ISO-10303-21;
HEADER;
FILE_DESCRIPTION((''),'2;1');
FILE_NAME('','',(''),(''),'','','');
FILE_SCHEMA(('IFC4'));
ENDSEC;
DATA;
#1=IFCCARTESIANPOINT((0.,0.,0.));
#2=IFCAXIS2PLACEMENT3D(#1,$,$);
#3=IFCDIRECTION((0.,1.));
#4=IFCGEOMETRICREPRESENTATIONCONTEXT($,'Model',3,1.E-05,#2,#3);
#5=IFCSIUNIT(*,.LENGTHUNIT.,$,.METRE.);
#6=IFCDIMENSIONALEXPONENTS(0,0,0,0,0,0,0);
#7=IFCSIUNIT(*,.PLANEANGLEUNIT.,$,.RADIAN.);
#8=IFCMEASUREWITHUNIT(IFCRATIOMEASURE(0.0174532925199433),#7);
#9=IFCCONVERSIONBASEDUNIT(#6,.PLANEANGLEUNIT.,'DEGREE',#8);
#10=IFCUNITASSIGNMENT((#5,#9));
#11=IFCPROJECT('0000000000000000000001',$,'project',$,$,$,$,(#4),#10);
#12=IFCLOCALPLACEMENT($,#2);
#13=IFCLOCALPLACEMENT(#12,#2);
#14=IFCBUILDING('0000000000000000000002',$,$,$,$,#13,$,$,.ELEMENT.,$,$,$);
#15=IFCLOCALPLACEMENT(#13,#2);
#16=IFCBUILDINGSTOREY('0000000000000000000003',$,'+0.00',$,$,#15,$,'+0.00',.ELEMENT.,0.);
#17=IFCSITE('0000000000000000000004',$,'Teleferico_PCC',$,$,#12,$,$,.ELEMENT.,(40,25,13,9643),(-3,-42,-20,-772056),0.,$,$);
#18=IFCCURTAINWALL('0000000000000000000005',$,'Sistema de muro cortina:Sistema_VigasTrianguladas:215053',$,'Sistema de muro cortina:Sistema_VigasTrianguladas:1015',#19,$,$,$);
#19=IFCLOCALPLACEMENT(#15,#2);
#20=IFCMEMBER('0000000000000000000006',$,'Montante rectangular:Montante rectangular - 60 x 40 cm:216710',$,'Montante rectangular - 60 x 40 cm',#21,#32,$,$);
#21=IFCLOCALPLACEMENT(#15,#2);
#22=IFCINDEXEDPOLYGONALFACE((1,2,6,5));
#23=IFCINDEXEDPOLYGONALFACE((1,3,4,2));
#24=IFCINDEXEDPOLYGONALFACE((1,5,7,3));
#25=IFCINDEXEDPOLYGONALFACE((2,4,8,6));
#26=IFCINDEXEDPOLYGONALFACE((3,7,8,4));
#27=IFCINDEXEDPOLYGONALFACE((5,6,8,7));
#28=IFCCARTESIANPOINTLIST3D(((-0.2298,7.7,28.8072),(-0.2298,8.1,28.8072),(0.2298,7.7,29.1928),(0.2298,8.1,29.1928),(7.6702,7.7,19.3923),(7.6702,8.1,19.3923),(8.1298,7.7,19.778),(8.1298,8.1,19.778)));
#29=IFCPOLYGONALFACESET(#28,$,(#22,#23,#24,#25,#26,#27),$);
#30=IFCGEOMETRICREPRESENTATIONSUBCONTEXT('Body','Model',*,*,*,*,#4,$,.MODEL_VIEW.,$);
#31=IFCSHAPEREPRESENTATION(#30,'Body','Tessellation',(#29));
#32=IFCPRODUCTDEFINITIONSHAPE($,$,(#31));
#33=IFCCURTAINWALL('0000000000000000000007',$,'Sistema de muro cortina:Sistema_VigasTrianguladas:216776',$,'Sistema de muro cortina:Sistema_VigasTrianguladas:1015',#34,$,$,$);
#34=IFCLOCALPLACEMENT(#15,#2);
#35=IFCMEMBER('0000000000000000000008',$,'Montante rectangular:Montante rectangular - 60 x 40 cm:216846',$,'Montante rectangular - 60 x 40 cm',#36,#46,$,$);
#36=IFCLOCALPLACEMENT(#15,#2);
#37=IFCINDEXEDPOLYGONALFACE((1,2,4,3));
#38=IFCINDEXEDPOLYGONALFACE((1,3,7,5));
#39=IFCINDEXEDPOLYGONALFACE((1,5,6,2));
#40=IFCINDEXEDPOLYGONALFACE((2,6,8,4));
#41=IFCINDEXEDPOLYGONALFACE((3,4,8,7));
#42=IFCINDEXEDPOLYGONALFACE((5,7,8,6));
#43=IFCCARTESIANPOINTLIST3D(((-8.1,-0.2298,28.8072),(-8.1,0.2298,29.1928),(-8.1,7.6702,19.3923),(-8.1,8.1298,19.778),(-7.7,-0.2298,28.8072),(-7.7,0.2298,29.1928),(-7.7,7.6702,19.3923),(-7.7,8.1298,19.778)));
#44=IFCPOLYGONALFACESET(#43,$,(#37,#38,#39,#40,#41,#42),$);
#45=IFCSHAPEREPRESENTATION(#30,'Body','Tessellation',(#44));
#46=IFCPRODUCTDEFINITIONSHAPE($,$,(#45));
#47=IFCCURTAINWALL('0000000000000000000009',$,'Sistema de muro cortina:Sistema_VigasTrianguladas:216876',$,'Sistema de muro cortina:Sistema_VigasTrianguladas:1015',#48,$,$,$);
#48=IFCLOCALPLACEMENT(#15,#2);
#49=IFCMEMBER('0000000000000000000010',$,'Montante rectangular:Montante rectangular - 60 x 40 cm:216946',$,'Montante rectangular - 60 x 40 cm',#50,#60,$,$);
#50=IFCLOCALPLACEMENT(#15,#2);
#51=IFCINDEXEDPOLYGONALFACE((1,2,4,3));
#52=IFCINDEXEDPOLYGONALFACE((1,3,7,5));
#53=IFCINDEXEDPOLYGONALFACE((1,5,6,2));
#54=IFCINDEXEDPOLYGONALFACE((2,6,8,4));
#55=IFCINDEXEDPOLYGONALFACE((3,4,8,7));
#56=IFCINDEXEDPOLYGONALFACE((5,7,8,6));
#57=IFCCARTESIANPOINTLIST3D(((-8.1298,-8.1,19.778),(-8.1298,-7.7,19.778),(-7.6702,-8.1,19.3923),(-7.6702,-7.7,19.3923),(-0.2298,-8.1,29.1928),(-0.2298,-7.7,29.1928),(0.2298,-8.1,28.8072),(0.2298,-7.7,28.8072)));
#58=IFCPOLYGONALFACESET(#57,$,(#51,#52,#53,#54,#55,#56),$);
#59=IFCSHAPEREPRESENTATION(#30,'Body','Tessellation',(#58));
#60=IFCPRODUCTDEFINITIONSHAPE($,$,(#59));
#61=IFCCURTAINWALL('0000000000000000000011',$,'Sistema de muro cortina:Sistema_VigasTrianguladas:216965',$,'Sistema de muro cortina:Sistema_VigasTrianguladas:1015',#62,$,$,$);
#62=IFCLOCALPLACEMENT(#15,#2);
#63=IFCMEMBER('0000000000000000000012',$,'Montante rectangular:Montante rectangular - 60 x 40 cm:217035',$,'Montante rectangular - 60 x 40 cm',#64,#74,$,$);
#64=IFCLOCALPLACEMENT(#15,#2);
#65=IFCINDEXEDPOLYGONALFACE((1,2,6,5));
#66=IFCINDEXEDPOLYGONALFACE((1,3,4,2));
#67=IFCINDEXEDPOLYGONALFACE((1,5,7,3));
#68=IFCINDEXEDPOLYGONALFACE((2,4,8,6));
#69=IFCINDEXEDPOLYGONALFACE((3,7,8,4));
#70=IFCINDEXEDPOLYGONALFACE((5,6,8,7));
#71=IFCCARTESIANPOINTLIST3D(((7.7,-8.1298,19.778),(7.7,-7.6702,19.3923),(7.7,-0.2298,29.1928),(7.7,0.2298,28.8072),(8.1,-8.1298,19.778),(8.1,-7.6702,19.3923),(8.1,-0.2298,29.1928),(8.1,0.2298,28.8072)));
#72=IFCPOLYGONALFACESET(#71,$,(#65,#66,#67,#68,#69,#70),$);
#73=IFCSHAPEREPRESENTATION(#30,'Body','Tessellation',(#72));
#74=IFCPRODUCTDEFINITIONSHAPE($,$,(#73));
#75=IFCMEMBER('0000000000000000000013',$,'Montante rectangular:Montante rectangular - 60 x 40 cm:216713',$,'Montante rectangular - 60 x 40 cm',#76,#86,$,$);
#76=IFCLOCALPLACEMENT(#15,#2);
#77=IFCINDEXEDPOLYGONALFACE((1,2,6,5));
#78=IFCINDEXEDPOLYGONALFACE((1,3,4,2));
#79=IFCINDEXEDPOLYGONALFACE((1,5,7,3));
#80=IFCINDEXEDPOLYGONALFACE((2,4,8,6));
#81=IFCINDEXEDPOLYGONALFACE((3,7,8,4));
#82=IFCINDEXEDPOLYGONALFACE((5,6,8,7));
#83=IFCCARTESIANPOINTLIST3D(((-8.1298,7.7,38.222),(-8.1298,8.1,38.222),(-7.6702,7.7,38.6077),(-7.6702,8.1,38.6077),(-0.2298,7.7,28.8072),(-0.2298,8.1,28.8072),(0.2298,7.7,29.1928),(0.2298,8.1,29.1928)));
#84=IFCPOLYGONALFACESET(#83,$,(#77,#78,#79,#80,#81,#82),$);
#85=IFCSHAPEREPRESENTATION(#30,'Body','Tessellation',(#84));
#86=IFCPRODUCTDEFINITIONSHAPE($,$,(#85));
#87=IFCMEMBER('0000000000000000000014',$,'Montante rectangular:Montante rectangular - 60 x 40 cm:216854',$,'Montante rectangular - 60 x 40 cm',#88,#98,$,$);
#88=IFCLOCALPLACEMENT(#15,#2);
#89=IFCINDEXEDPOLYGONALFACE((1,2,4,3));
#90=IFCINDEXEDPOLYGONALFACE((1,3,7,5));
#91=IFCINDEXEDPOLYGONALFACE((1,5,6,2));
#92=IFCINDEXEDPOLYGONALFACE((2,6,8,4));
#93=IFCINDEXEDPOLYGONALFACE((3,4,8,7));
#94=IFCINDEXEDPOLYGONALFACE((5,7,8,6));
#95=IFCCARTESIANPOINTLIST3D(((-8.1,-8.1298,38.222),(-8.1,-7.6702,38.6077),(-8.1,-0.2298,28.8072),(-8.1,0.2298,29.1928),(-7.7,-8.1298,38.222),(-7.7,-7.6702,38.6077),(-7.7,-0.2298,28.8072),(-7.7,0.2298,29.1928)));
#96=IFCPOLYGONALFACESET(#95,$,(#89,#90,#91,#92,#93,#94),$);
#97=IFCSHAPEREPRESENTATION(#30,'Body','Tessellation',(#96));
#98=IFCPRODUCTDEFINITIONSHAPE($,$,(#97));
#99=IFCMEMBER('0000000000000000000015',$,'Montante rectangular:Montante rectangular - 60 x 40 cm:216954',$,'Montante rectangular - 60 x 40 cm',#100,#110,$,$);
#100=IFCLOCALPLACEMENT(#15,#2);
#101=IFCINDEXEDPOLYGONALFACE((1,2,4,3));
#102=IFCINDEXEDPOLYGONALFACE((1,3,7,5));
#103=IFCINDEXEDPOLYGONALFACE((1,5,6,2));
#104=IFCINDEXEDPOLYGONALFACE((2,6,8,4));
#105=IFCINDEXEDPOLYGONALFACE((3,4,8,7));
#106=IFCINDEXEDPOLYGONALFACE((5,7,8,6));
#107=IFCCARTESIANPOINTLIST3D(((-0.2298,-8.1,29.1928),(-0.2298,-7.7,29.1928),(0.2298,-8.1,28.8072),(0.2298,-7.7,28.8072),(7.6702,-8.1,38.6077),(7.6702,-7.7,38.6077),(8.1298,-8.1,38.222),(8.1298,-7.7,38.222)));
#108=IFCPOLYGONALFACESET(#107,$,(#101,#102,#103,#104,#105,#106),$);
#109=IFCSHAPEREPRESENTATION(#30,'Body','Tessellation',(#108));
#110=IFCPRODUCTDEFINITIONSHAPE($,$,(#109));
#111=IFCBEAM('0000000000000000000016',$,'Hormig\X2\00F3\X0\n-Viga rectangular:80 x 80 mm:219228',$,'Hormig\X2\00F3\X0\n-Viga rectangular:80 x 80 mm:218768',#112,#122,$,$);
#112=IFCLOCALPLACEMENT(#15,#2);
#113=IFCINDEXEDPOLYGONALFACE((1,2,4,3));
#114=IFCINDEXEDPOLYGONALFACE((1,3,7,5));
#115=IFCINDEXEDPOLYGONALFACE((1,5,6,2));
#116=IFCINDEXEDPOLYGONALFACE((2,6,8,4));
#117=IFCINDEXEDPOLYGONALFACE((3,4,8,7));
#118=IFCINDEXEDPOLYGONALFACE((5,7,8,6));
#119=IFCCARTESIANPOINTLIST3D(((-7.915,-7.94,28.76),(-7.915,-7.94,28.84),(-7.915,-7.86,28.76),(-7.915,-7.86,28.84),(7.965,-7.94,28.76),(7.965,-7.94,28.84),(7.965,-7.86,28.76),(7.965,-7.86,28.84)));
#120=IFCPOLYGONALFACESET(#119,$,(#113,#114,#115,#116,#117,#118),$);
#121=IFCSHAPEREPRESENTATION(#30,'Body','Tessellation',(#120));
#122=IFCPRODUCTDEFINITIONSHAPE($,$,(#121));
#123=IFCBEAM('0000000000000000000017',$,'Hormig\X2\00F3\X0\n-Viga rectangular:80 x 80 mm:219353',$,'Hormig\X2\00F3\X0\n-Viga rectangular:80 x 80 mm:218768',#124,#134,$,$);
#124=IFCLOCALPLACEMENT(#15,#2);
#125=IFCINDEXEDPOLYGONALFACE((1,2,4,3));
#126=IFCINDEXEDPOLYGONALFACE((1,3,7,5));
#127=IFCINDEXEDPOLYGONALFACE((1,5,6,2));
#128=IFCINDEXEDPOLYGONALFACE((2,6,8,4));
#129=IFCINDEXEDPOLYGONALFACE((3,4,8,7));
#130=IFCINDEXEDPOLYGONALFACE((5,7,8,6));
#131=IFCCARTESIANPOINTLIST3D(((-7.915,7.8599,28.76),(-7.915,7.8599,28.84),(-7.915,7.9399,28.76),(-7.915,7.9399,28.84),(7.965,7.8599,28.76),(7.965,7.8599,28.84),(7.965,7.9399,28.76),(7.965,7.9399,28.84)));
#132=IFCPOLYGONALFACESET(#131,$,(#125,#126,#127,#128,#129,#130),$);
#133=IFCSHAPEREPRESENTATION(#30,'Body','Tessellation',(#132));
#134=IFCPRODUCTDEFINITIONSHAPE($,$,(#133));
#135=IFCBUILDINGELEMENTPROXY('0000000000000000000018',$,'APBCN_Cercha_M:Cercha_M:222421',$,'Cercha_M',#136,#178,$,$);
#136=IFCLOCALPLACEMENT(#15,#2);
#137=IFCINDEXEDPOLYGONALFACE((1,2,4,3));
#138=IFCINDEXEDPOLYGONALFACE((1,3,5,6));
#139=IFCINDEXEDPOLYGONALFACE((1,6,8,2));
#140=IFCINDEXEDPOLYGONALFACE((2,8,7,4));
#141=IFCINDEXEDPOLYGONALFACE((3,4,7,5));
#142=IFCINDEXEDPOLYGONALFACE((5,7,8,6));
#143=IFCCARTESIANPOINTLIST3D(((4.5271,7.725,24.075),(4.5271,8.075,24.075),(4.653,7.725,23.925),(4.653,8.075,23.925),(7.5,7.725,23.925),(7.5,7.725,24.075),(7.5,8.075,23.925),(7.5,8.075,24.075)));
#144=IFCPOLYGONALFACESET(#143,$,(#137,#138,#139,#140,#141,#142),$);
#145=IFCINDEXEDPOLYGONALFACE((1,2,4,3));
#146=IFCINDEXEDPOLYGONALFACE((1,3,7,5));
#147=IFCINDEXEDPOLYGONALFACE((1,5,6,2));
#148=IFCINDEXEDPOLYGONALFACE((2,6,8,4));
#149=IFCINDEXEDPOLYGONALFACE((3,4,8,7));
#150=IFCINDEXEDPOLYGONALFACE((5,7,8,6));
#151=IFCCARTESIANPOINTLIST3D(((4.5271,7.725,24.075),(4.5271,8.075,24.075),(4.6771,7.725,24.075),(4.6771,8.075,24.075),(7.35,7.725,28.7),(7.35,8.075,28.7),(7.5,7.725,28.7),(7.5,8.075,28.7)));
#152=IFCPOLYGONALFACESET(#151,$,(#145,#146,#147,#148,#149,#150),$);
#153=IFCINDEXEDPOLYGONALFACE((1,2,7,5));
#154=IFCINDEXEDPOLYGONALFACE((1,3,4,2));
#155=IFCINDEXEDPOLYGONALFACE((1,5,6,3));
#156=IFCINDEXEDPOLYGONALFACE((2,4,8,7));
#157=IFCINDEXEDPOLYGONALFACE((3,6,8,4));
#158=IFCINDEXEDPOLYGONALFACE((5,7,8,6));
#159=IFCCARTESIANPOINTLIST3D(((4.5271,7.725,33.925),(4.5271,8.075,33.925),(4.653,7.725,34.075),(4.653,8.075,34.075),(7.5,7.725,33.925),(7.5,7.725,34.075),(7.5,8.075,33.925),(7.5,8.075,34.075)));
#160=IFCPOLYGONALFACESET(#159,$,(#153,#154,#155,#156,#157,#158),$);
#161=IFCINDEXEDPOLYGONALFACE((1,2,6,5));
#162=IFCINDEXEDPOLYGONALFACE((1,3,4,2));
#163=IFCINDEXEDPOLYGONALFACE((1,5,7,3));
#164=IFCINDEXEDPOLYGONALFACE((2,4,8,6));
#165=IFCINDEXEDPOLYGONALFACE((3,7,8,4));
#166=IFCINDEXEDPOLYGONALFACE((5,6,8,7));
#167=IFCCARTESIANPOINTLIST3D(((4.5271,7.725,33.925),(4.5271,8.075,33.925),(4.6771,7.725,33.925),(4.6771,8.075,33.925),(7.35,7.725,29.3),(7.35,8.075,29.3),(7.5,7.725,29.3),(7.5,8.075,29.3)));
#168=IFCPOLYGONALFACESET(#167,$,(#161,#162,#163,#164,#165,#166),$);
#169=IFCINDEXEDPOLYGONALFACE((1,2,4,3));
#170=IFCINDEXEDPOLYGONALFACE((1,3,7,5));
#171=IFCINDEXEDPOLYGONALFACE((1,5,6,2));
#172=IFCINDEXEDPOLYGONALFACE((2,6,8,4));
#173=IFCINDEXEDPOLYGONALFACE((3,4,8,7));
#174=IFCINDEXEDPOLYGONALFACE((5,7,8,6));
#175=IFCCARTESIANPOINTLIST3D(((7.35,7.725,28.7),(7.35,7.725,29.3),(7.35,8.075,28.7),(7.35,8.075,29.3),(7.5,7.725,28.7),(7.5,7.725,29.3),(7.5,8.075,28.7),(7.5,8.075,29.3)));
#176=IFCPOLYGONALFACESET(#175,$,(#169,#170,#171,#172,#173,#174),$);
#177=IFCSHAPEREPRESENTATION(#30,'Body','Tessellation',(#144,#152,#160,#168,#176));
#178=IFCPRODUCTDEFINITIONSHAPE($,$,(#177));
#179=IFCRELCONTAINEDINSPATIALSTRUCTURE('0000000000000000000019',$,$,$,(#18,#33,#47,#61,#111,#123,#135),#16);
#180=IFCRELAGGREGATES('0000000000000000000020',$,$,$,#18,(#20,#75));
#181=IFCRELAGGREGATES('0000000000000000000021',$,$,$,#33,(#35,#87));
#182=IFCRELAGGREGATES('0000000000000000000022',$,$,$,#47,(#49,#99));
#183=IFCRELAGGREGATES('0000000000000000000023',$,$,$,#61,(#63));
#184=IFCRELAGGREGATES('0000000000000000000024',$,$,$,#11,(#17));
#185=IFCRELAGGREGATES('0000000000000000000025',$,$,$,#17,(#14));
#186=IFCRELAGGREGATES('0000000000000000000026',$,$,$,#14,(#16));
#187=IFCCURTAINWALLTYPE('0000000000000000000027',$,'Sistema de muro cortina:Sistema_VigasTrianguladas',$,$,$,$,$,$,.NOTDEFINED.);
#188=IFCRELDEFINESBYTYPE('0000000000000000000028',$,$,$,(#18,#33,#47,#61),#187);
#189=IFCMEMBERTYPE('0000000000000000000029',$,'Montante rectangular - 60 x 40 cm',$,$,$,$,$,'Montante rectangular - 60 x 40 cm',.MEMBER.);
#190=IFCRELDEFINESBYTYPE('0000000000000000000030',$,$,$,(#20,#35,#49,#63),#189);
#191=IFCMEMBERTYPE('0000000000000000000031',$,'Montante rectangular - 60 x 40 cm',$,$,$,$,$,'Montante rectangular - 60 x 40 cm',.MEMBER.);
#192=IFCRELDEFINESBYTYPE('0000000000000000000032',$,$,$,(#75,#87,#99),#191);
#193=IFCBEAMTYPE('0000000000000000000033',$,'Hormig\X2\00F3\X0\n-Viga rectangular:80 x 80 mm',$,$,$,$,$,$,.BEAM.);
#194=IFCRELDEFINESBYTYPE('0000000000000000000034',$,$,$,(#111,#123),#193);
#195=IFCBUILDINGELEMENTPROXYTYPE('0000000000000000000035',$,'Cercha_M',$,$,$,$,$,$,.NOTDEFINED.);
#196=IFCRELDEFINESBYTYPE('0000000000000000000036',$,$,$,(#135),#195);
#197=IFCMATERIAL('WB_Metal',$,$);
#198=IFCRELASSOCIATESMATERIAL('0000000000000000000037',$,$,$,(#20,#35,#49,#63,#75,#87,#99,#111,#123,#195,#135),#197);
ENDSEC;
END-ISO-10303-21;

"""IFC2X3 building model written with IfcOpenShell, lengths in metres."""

from ifc_helpers import new_model, entity, si_unit, converted_unit, direction, frame, frame_2d, origin, origin_2d_with_axis, place, context, subcontext, project, spatial, polyline, rectangle, outline, extrude, source, transform, mapped, material, type_object, type_shapes, element, aggregate, save


model = new_model("IFC2X3")

# Units and contexts
model_context = context("Model", 3, precision=1e-05, world=origin(), true_north=direction((0.0, 1.0)))
body_context = subcontext(model_context, "Body", "Model", "MODEL_VIEW")
ifc_project = project(units=[si_unit("LENGTHUNIT", "METRE"), converted_unit("PLANEANGLEUNIT", "DEGREE", entity("IfcRatioMeasure", 0.0174532925199433), si_unit("PLANEANGLEUNIT", "RADIAN"), dimensions=[0, 0, 0, 0, 0, 0, 0])], contexts=[model_context])

# Site, building, storey
site_placement = place(None, origin())
site = spatial("IfcSite", under=ifc_project, at=site_placement, Name="Teleferico_PCC", CompositionType="ELEMENT", RefLatitude=(40, 25, 13, 9643), RefLongitude=(-3, -42, -20, -772056), RefElevation=0.0)
building_placement = place(site_placement, origin())
building = spatial("IfcBuilding", under=site, at=building_placement, CompositionType="ELEMENT")
storey_placement = place(building_placement, origin())
storey = spatial("IfcBuildingStorey", under=building, at=storey_placement, Name="+0.00", LongName="+0.00", CompositionType="ELEMENT", Elevation=0.0)

# Curtain walls, members
curtain_wall_type = type_object("IfcCurtainWallType", Name="Sistema de muro cortina:Sistema_VigasTrianguladas", PredefinedType="NOTDEFINED")
curtain_wall_1_placement = place(storey_placement, origin())
curtain_wall_1 = element("IfcCurtainWall", 1, at=curtain_wall_1_placement, inside=storey, type_object=curtain_wall_type, Name="Sistema de muro cortina:Sistema_VigasTrianguladas:215053", ObjectType="Sistema de muro cortina:Sistema_VigasTrianguladas:1015")
ifc_material = material(Name="WB_Metal")
member_type_1 = type_object("IfcMemberType", Name="Montante rectangular - 60 x 40 cm", ElementType="Montante rectangular - 60 x 40 cm", PredefinedType="MEMBER")
shared_shape_1 = source(origin(), body_context, "Body", "SweptSolid", [
    extrude(rectangle(XDim=0.4, YDim=0.6, at=frame_2d((0.0, 0.0), x_axis=(1.0, 0.0))), frame((0.0, 0.0, -12.2902), z_axis=(0.0, 0.0, 1.0), x_axis=(0.0, -1.0, 0.0)), (0.0, 0.0, 1.0), 12.2902),
])
type_shapes(member_type_1, [shared_shape_1])
member_1_placement = place(storey_placement, frame((0.0, 7.9, 29.0), z_axis=(-0.642788, 0.0, 0.766044), x_axis=(0.766044, 0.0, 0.642788)))
member_1 = element("IfcMember", 2, at=member_1_placement, type_object=member_type_1, material=ifc_material, Name="Montante rectangular:Montante rectangular - 60 x 40 cm:216710", ObjectType="Montante rectangular - 60 x 40 cm", context=body_context, shape_type="MappedRepresentation", body=[
    mapped(shared_shape_1, transform((0.0, 0.0, 0.0), scale=1.0)),
])
curtain_wall_2_placement = place(storey_placement, origin())
curtain_wall_2 = element("IfcCurtainWall", 3, at=curtain_wall_2_placement, inside=storey, type_object=curtain_wall_type, Name="Sistema de muro cortina:Sistema_VigasTrianguladas:216776", ObjectType="Sistema de muro cortina:Sistema_VigasTrianguladas:1015")
member_2_placement = place(storey_placement, frame((-7.9, 0.0, 29.0), z_axis=(0.0, -0.642788, 0.766044), x_axis=(0.0, 0.766044, 0.642788)))
member_2 = element("IfcMember", 4, at=member_2_placement, type_object=member_type_1, material=ifc_material, Name="Montante rectangular:Montante rectangular - 60 x 40 cm:216846", ObjectType="Montante rectangular - 60 x 40 cm", context=body_context, shape_type="MappedRepresentation", body=[
    mapped(shared_shape_1, transform((0.0, 0.0, 0.0), scale=1.0)),
])
curtain_wall_3_placement = place(storey_placement, origin())
curtain_wall_3 = element("IfcCurtainWall", 5, at=curtain_wall_3_placement, inside=storey, type_object=curtain_wall_type, Name="Sistema de muro cortina:Sistema_VigasTrianguladas:216876", ObjectType="Sistema de muro cortina:Sistema_VigasTrianguladas:1015")
member_3_placement = place(storey_placement, frame((0.0, -7.9, 29.0), z_axis=(0.642788, 0.0, 0.766044), x_axis=(-0.766044, 0.0, 0.642788)))
member_3 = element("IfcMember", 6, at=member_3_placement, type_object=member_type_1, material=ifc_material, Name="Montante rectangular:Montante rectangular - 60 x 40 cm:216946", ObjectType="Montante rectangular - 60 x 40 cm", context=body_context, shape_type="MappedRepresentation", body=[
    mapped(shared_shape_1, transform((0.0, 0.0, 0.0), scale=1.0)),
])
curtain_wall_4_placement = place(storey_placement, origin())
curtain_wall_4 = element("IfcCurtainWall", 7, at=curtain_wall_4_placement, inside=storey, type_object=curtain_wall_type, Name="Sistema de muro cortina:Sistema_VigasTrianguladas:216965", ObjectType="Sistema de muro cortina:Sistema_VigasTrianguladas:1015")
member_4_placement = place(storey_placement, frame((7.9, 0.0, 29.0), z_axis=(0.0, 0.642788, 0.766044), x_axis=(0.0, -0.766044, 0.642788)))
member_4 = element("IfcMember", 8, at=member_4_placement, type_object=member_type_1, material=ifc_material, Name="Montante rectangular:Montante rectangular - 60 x 40 cm:217035", ObjectType="Montante rectangular - 60 x 40 cm", context=body_context, shape_type="MappedRepresentation", body=[
    mapped(shared_shape_1, transform((0.0, 0.0, 0.0), scale=1.0)),
])

# Members
member_type_2 = type_object("IfcMemberType", Name="Montante rectangular - 60 x 40 cm", ElementType="Montante rectangular - 60 x 40 cm", PredefinedType="MEMBER")
shared_shape_2 = source(origin(), body_context, "Body", "SweptSolid", [
    extrude(rectangle(XDim=0.4, YDim=0.6, at=origin_2d_with_axis()), frame((0.0, 0.0, -12.2902), z_axis=(0.0, 0.0, 1.0), x_axis=(0.0, -1.0, 0.0)), (0.0, 0.0, 1.0), 12.2902),
])
type_shapes(member_type_2, [shared_shape_2])
member_5_placement = place(storey_placement, frame((-7.9, 7.9, 38.4149), z_axis=(-0.642788, 0.0, 0.766044), x_axis=(0.766044, 0.0, 0.642788)))
member_5 = element("IfcMember", 9, at=member_5_placement, type_object=member_type_2, material=ifc_material, Name="Montante rectangular:Montante rectangular - 60 x 40 cm:216713", ObjectType="Montante rectangular - 60 x 40 cm", context=body_context, shape_type="MappedRepresentation", body=[
    mapped(shared_shape_2, transform((0.0, 0.0, 0.0), scale=1.0)),
])
member_6_placement = place(storey_placement, frame((-7.9, -7.9, 38.4149), z_axis=(0.0, -0.642788, 0.766044), x_axis=(0.0, 0.766044, 0.642788)))
member_6 = element("IfcMember", 10, at=member_6_placement, type_object=member_type_2, material=ifc_material, Name="Montante rectangular:Montante rectangular - 60 x 40 cm:216854", ObjectType="Montante rectangular - 60 x 40 cm", context=body_context, shape_type="MappedRepresentation", body=[
    mapped(shared_shape_2, transform((0.0, 0.0, 0.0), scale=1.0)),
])
member_7_placement = place(storey_placement, frame((7.9, -7.9, 38.4149), z_axis=(0.642788, 0.0, 0.766044), x_axis=(-0.766044, 0.0, 0.642788)))
member_7 = element("IfcMember", 11, at=member_7_placement, type_object=member_type_2, material=ifc_material, Name="Montante rectangular:Montante rectangular - 60 x 40 cm:216954", ObjectType="Montante rectangular - 60 x 40 cm", context=body_context, shape_type="MappedRepresentation", body=[
    mapped(shared_shape_2, transform((0.0, 0.0, 0.0), scale=1.0)),
])
aggregate(curtain_wall_1, [member_1, member_5])
aggregate(curtain_wall_2, [member_2, member_6])
aggregate(curtain_wall_3, [member_3, member_7])
aggregate(curtain_wall_4, [member_4])

# Beams
beam_type = type_object("IfcBeamType", Name="Hormigón-Viga rectangular:80 x 80 mm", PredefinedType="BEAM")
beam_1_placement = place(storey_placement, frame((-7.875, -7.9, 28.8)))
element("IfcBeam", 12, at=beam_1_placement, inside=storey, type_object=beam_type, material=ifc_material, Name="Hormigón-Viga rectangular:80 x 80 mm:219228", ObjectType="Hormigón-Viga rectangular:80 x 80 mm:218768", context=body_context, shape_type="SweptSolid", body=[
    extrude(rectangle(XDim=0.08, YDim=0.08, at=frame_2d((0.0, 0.0), x_axis=(1.0, 0.0))), frame((-0.04, 0.0, 0.0), z_axis=(1.0, 0.0, 0.0), x_axis=(0.0, 0.0, -1.0)), (0.0, 0.0, 1.0), 15.88),
])
beam_2_placement = place(storey_placement, frame((-7.875, 7.8999, 28.8)))
element("IfcBeam", 13, at=beam_2_placement, inside=storey, type_object=beam_type, material=ifc_material, Name="Hormigón-Viga rectangular:80 x 80 mm:219353", ObjectType="Hormigón-Viga rectangular:80 x 80 mm:218768", context=body_context, shape_type="SweptSolid", body=[
    extrude(rectangle(XDim=0.08, YDim=0.08, at=frame_2d((0.0, 0.0), x_axis=(1.0, 0.0))), frame((-0.04, 0.0, 0.0), z_axis=(1.0, 0.0, 0.0), x_axis=(0.0, 0.0, -1.0)), (0.0, 0.0, 1.0), 15.88),
])

# Building element proxy
building_element_proxy_type_1 = type_object("IfcBuildingElementProxyType", Name="Cercha_M", PredefinedType="NOTDEFINED", material=ifc_material)
shared_shape_3 = source(origin(), body_context, "Body", "SweptSolid", [
    extrude(outline(polyline([(-1.455, -0.075), (1.3921, -0.075), (1.5179, 0.075), (-1.455, 0.075), (-1.455, -0.075)])), frame((-1.455, -0.175, -5.0), z_axis=(0.0, 1.0, 0.0), x_axis=(-1.0, 0.0, 0.0)), (0.0, 0.0, 1.0), 0.35),
    extrude(outline(polyline([(1.3365, -2.3125), (1.4865, -2.3125), (-1.3365, 2.3125), (-1.4865, 2.3125), (1.3365, -2.3125)])), frame((-1.4865, -0.175, -2.6125), z_axis=(0.0, 1.0, 0.0), x_axis=(1.0, 0.0, 0.0)), (0.0, 0.0, 1.0), 0.35),
    extrude(outline(polyline([(-1.455, -0.075), (1.5179, -0.075), (1.3921, 0.075), (-1.455, 0.075), (-1.455, -0.075)])), frame((-1.455, -0.175, 5.0), z_axis=(0.0, 1.0, 0.0), x_axis=(-1.0, 0.0, 0.0)), (0.0, 0.0, 1.0), 0.35),
    extrude(outline(polyline([(-2.6701, -0.064), (2.7483, -0.064), (2.6701, 0.064), (-2.7483, 0.064), (-2.6701, -0.064)])), frame((-1.4865, -0.175, 2.6125), z_axis=(0.0, 1.0, 0.0), x_axis=(-0.520985, 0.0, 0.853566)), (0.0, 0.0, 1.0), 0.35),
    extrude(rectangle(XDim=0.35, YDim=0.15, at=origin_2d_with_axis()), frame((-0.075, 0.0, -0.3), z_axis=(0.0, 0.0, 1.0), x_axis=(0.0, 1.0, 0.0)), (0.0, 0.0, 1.0), 0.6),
])
type_shapes(building_element_proxy_type_1, [shared_shape_3])
for number, where, name in (
    (14, (7.5, 7.9, 29.0), "APBCN_Cercha_M:Cercha_M:222421"),
):
    element("IfcBuildingElementProxy", number, at=place(storey_placement, frame(where)), inside=storey, type_object=building_element_proxy_type_1, material=ifc_material, Name=name, ObjectType="Cercha_M", context=body_context, shape_type="MappedRepresentation", body=[
        mapped(shared_shape_3, transform((0.0, 0.0, 0.0), scale=1.0)),
    ])

save(model, "model.ifc")
